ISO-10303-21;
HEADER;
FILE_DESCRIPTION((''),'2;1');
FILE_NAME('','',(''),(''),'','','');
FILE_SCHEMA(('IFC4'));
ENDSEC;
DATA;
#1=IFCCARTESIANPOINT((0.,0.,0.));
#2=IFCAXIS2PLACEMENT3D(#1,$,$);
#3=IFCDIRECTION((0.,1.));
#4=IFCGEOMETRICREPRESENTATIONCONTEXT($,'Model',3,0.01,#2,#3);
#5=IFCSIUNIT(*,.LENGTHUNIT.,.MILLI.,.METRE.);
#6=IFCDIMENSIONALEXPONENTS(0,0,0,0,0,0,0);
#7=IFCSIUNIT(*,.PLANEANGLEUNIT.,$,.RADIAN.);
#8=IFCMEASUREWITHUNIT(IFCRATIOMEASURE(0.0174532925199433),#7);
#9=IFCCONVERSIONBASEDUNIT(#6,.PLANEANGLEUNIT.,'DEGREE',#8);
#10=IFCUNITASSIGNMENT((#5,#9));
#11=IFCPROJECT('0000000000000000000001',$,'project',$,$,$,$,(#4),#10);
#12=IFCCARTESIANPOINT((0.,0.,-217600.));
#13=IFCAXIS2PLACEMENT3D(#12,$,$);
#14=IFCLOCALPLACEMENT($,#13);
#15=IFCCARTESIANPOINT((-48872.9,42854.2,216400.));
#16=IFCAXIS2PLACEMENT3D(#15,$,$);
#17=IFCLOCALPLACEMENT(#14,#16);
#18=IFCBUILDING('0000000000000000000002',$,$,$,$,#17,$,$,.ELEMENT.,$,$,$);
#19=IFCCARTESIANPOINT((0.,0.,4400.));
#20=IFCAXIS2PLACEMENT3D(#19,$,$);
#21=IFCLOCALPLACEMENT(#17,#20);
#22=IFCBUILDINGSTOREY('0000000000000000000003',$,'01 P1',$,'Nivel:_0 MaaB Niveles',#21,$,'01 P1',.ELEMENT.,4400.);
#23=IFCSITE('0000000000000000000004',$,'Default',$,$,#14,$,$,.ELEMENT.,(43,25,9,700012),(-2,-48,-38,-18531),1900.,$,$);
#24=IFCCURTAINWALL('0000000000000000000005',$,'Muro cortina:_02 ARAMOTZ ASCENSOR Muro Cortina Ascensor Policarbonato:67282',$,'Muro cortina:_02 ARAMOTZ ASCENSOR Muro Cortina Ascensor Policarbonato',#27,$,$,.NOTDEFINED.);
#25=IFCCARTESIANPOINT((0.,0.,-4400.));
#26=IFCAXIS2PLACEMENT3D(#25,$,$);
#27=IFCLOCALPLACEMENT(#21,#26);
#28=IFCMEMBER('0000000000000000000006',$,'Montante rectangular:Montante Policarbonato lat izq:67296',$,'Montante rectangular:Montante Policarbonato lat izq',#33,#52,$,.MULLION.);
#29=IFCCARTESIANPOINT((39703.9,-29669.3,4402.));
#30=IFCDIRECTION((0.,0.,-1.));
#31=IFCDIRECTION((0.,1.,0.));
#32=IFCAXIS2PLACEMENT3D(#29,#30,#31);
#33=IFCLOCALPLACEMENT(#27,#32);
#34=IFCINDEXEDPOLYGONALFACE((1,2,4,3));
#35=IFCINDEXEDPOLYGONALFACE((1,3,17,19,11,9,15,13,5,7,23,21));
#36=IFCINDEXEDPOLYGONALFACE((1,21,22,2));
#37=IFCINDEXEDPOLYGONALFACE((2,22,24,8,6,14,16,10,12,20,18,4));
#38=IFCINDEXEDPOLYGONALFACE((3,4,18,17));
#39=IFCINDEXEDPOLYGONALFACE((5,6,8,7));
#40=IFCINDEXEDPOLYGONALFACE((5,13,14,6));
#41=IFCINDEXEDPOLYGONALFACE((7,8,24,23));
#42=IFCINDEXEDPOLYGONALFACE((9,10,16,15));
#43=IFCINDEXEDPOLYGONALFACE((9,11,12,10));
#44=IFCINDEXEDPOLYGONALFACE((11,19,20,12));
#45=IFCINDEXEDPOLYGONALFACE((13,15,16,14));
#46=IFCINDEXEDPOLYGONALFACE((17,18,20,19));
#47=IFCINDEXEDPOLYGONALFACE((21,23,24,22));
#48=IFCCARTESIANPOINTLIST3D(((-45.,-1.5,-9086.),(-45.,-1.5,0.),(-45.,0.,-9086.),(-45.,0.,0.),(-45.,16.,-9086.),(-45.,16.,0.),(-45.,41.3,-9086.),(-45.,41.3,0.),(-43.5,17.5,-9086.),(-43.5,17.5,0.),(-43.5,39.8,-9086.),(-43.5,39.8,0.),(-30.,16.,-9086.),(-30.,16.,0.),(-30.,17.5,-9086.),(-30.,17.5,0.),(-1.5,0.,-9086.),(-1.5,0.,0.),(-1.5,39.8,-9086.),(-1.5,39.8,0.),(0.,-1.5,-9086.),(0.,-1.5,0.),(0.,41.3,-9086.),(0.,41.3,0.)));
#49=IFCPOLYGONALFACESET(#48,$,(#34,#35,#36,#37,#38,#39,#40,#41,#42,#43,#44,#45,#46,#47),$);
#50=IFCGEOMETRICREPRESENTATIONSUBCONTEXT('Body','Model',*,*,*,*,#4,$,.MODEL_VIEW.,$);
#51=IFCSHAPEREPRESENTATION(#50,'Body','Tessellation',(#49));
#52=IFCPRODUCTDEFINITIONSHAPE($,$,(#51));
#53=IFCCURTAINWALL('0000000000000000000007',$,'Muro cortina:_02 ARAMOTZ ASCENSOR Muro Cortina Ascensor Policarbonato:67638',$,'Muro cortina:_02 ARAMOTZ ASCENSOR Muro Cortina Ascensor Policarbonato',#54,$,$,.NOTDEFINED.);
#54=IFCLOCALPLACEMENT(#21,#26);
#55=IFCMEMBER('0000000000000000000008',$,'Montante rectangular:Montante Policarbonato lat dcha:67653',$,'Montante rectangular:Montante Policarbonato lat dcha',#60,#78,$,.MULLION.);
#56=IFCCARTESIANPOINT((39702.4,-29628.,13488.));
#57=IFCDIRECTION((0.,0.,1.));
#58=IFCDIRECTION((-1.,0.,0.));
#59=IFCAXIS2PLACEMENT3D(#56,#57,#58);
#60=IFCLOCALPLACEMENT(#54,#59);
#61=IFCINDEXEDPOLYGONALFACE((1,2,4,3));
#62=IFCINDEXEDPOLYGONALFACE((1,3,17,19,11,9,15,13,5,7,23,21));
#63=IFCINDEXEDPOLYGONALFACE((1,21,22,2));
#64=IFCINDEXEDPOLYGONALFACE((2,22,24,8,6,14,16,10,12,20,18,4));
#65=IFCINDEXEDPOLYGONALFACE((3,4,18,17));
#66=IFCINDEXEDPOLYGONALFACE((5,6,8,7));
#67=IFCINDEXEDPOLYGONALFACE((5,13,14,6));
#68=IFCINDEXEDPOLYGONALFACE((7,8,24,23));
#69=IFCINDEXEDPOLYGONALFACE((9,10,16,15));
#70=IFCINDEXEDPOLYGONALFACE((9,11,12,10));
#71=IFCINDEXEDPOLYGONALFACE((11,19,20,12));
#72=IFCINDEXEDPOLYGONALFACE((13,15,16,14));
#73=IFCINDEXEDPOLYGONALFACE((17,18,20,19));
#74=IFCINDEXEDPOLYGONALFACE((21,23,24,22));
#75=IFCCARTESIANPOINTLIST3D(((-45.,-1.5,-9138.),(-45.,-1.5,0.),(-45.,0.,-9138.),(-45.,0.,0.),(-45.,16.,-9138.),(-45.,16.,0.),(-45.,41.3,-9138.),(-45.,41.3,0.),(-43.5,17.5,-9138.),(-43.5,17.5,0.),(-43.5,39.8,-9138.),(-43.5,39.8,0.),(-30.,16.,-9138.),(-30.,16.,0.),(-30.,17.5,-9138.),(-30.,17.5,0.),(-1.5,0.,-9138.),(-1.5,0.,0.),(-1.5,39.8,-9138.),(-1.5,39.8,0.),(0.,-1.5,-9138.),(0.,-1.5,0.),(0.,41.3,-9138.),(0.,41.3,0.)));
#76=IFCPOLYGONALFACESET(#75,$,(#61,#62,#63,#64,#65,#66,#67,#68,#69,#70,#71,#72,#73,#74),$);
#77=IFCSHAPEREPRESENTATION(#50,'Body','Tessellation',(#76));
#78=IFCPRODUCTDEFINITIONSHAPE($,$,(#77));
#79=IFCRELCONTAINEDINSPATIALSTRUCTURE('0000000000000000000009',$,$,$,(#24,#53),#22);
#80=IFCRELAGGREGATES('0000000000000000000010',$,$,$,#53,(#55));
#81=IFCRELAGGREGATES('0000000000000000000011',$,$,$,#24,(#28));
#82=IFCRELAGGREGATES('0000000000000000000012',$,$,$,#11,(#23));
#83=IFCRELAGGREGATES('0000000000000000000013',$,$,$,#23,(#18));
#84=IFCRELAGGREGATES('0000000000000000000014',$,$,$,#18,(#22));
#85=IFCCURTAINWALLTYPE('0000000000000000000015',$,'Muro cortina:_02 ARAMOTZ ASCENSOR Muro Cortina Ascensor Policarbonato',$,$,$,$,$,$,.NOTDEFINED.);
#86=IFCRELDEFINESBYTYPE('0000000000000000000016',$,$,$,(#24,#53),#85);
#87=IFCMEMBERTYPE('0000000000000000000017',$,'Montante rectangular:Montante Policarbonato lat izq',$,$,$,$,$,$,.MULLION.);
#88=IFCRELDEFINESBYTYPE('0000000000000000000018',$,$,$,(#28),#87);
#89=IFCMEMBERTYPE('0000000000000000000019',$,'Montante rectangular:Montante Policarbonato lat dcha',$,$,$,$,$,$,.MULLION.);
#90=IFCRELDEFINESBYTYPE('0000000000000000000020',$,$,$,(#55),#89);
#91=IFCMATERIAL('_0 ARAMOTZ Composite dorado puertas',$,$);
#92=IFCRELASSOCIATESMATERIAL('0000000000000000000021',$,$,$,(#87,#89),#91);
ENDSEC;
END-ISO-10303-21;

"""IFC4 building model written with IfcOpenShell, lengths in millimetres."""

from ifc_helpers import new_model, entity, si_unit, converted_unit, direction, frame, origin, place, context, subcontext, project, spatial, indexed_curve, outline, extrude, source, transform, mapped, material, type_object, type_shapes, element, aggregate, save


model = new_model("IFC4")

# Units and contexts
model_context = context("Model", 3, precision=0.01, world=origin(), true_north=direction((0.0, 1.0)))
body_context = subcontext(model_context, "Body", "Model", "MODEL_VIEW")
ifc_project = project(units=[si_unit("LENGTHUNIT", "METRE", prefix="MILLI"), converted_unit("PLANEANGLEUNIT", "DEGREE", entity("IfcRatioMeasure", 0.0174532925199433), si_unit("PLANEANGLEUNIT", "RADIAN"), dimensions=[0, 0, 0, 0, 0, 0, 0])], contexts=[model_context])

# Site, building, storey
site_placement = place(None, frame((0.0, 0.0, -217600.0)))
site = spatial("IfcSite", under=ifc_project, at=site_placement, Name="Default", CompositionType="ELEMENT", RefLatitude=(43, 25, 9, 700012), RefLongitude=(-2, -48, -38, -18531), RefElevation=1900.0)
building_placement = place(site_placement, frame((-48872.9, 42854.2, 216400.0)))
building = spatial("IfcBuilding", under=site, at=building_placement, CompositionType="ELEMENT")
storey_placement = place(building_placement, frame((0.0, 0.0, 4400.0)))
storey = spatial("IfcBuildingStorey", under=building, at=storey_placement, Name="01 P1", ObjectType="Nivel:_0 MaaB Niveles", LongName="01 P1", CompositionType="ELEMENT", Elevation=4400.0)

# Curtain wall, member
curtain_wall_type_1 = type_object("IfcCurtainWallType", Name="Muro cortina:_02 ARAMOTZ ASCENSOR Muro Cortina Ascensor Policarbonato", PredefinedType="NOTDEFINED")
curtain_wall_1_placement = place(storey_placement, frame((0.0, 0.0, -4400.0)))
curtain_wall_1 = element("IfcCurtainWall", 1, at=curtain_wall_1_placement, inside=storey, type_object=curtain_wall_type_1, Name="Muro cortina:_02 ARAMOTZ ASCENSOR Muro Cortina Ascensor Policarbonato:67282", ObjectType="Muro cortina:_02 ARAMOTZ ASCENSOR Muro Cortina Ascensor Policarbonato", PredefinedType="NOTDEFINED")
ifc_material_1 = material(Name="_0 ARAMOTZ Composite dorado puertas")
member_type_1 = type_object("IfcMemberType", Name="Montante rectangular:Montante Policarbonato lat izq", PredefinedType="MULLION", material=ifc_material_1)
shared_shape_1 = source(origin(), body_context, "Body", "SweptSolid", [
    extrude(outline(indexed_curve([(18.9, -17.5), (20.4, -17.5), (20.4, 27.5), (-22.5, 27.5), (-22.5, -17.5), (2.9, -17.5), (2.9, -2.5), (1.4, -2.5), (1.4, -16.0), (-21.0, -16.0), (-21.0, 26.0), (18.9, 26.0), (18.9, -17.5)], self_intersect=False)), frame((-27.5, 18.9, -9086.0), z_axis=(0.0, 0.0, 1.0), x_axis=(0.0, -1.0, 0.0)), (0.0, 0.0, 1.0), 9086.0),
])
type_shapes(member_type_1, [shared_shape_1])
member_1_placement = place(curtain_wall_1_placement, frame((39703.9, -29669.3, 4402.0), z_axis=(0.0, 0.0, -1.0), x_axis=(0.0, 1.0, 0.0)))
member_1 = element("IfcMember", 2, at=member_1_placement, type_object=member_type_1, Name="Montante rectangular:Montante Policarbonato lat izq:67296", ObjectType="Montante rectangular:Montante Policarbonato lat izq", PredefinedType="MULLION", context=body_context, shape_type="MappedRepresentation", body=[
    mapped(shared_shape_1, transform((0.0, 0.0, 0.0), scale=1.0)),
])

# Curtain wall, member
curtain_wall_2_placement = place(storey_placement, frame((0.0, 0.0, -4400.0)))
curtain_wall_2 = element("IfcCurtainWall", 3, at=curtain_wall_2_placement, inside=storey, type_object=curtain_wall_type_1, Name="Muro cortina:_02 ARAMOTZ ASCENSOR Muro Cortina Ascensor Policarbonato:67638", ObjectType="Muro cortina:_02 ARAMOTZ ASCENSOR Muro Cortina Ascensor Policarbonato", PredefinedType="NOTDEFINED")
member_type_2 = type_object("IfcMemberType", Name="Montante rectangular:Montante Policarbonato lat dcha", PredefinedType="MULLION", material=ifc_material_1)
shared_shape_2 = source(origin(), body_context, "Body", "SweptSolid", [
    extrude(outline(indexed_curve([(18.9, -17.5), (20.4, -17.5), (20.4, 27.5), (-22.5, 27.5), (-22.5, -17.5), (2.9, -17.5), (2.9, -2.5), (1.4, -2.5), (1.4, -16.0), (-21.0, -16.0), (-21.0, 26.0), (18.9, 26.0), (18.9, -17.5)], self_intersect=False)), frame((-27.5, 18.9, -9138.0), z_axis=(0.0, 0.0, 1.0), x_axis=(0.0, -1.0, 0.0)), (0.0, 0.0, 1.0), 9138.0),
])
type_shapes(member_type_2, [shared_shape_2])
member_2_placement = place(curtain_wall_2_placement, frame((39702.4, -29628.0, 13488.0), z_axis=(0.0, 0.0, 1.0), x_axis=(-1.0, 0.0, 0.0)))
member_2 = element("IfcMember", 4, at=member_2_placement, type_object=member_type_2, Name="Montante rectangular:Montante Policarbonato lat dcha:67653", ObjectType="Montante rectangular:Montante Policarbonato lat dcha", PredefinedType="MULLION", context=body_context, shape_type="MappedRepresentation", body=[
    mapped(shared_shape_2, transform((0.0, 0.0, 0.0), scale=1.0)),
])
aggregate(curtain_wall_2, [member_2])

aggregate(curtain_wall_1, [member_1])

save(model, "model.ifc")
